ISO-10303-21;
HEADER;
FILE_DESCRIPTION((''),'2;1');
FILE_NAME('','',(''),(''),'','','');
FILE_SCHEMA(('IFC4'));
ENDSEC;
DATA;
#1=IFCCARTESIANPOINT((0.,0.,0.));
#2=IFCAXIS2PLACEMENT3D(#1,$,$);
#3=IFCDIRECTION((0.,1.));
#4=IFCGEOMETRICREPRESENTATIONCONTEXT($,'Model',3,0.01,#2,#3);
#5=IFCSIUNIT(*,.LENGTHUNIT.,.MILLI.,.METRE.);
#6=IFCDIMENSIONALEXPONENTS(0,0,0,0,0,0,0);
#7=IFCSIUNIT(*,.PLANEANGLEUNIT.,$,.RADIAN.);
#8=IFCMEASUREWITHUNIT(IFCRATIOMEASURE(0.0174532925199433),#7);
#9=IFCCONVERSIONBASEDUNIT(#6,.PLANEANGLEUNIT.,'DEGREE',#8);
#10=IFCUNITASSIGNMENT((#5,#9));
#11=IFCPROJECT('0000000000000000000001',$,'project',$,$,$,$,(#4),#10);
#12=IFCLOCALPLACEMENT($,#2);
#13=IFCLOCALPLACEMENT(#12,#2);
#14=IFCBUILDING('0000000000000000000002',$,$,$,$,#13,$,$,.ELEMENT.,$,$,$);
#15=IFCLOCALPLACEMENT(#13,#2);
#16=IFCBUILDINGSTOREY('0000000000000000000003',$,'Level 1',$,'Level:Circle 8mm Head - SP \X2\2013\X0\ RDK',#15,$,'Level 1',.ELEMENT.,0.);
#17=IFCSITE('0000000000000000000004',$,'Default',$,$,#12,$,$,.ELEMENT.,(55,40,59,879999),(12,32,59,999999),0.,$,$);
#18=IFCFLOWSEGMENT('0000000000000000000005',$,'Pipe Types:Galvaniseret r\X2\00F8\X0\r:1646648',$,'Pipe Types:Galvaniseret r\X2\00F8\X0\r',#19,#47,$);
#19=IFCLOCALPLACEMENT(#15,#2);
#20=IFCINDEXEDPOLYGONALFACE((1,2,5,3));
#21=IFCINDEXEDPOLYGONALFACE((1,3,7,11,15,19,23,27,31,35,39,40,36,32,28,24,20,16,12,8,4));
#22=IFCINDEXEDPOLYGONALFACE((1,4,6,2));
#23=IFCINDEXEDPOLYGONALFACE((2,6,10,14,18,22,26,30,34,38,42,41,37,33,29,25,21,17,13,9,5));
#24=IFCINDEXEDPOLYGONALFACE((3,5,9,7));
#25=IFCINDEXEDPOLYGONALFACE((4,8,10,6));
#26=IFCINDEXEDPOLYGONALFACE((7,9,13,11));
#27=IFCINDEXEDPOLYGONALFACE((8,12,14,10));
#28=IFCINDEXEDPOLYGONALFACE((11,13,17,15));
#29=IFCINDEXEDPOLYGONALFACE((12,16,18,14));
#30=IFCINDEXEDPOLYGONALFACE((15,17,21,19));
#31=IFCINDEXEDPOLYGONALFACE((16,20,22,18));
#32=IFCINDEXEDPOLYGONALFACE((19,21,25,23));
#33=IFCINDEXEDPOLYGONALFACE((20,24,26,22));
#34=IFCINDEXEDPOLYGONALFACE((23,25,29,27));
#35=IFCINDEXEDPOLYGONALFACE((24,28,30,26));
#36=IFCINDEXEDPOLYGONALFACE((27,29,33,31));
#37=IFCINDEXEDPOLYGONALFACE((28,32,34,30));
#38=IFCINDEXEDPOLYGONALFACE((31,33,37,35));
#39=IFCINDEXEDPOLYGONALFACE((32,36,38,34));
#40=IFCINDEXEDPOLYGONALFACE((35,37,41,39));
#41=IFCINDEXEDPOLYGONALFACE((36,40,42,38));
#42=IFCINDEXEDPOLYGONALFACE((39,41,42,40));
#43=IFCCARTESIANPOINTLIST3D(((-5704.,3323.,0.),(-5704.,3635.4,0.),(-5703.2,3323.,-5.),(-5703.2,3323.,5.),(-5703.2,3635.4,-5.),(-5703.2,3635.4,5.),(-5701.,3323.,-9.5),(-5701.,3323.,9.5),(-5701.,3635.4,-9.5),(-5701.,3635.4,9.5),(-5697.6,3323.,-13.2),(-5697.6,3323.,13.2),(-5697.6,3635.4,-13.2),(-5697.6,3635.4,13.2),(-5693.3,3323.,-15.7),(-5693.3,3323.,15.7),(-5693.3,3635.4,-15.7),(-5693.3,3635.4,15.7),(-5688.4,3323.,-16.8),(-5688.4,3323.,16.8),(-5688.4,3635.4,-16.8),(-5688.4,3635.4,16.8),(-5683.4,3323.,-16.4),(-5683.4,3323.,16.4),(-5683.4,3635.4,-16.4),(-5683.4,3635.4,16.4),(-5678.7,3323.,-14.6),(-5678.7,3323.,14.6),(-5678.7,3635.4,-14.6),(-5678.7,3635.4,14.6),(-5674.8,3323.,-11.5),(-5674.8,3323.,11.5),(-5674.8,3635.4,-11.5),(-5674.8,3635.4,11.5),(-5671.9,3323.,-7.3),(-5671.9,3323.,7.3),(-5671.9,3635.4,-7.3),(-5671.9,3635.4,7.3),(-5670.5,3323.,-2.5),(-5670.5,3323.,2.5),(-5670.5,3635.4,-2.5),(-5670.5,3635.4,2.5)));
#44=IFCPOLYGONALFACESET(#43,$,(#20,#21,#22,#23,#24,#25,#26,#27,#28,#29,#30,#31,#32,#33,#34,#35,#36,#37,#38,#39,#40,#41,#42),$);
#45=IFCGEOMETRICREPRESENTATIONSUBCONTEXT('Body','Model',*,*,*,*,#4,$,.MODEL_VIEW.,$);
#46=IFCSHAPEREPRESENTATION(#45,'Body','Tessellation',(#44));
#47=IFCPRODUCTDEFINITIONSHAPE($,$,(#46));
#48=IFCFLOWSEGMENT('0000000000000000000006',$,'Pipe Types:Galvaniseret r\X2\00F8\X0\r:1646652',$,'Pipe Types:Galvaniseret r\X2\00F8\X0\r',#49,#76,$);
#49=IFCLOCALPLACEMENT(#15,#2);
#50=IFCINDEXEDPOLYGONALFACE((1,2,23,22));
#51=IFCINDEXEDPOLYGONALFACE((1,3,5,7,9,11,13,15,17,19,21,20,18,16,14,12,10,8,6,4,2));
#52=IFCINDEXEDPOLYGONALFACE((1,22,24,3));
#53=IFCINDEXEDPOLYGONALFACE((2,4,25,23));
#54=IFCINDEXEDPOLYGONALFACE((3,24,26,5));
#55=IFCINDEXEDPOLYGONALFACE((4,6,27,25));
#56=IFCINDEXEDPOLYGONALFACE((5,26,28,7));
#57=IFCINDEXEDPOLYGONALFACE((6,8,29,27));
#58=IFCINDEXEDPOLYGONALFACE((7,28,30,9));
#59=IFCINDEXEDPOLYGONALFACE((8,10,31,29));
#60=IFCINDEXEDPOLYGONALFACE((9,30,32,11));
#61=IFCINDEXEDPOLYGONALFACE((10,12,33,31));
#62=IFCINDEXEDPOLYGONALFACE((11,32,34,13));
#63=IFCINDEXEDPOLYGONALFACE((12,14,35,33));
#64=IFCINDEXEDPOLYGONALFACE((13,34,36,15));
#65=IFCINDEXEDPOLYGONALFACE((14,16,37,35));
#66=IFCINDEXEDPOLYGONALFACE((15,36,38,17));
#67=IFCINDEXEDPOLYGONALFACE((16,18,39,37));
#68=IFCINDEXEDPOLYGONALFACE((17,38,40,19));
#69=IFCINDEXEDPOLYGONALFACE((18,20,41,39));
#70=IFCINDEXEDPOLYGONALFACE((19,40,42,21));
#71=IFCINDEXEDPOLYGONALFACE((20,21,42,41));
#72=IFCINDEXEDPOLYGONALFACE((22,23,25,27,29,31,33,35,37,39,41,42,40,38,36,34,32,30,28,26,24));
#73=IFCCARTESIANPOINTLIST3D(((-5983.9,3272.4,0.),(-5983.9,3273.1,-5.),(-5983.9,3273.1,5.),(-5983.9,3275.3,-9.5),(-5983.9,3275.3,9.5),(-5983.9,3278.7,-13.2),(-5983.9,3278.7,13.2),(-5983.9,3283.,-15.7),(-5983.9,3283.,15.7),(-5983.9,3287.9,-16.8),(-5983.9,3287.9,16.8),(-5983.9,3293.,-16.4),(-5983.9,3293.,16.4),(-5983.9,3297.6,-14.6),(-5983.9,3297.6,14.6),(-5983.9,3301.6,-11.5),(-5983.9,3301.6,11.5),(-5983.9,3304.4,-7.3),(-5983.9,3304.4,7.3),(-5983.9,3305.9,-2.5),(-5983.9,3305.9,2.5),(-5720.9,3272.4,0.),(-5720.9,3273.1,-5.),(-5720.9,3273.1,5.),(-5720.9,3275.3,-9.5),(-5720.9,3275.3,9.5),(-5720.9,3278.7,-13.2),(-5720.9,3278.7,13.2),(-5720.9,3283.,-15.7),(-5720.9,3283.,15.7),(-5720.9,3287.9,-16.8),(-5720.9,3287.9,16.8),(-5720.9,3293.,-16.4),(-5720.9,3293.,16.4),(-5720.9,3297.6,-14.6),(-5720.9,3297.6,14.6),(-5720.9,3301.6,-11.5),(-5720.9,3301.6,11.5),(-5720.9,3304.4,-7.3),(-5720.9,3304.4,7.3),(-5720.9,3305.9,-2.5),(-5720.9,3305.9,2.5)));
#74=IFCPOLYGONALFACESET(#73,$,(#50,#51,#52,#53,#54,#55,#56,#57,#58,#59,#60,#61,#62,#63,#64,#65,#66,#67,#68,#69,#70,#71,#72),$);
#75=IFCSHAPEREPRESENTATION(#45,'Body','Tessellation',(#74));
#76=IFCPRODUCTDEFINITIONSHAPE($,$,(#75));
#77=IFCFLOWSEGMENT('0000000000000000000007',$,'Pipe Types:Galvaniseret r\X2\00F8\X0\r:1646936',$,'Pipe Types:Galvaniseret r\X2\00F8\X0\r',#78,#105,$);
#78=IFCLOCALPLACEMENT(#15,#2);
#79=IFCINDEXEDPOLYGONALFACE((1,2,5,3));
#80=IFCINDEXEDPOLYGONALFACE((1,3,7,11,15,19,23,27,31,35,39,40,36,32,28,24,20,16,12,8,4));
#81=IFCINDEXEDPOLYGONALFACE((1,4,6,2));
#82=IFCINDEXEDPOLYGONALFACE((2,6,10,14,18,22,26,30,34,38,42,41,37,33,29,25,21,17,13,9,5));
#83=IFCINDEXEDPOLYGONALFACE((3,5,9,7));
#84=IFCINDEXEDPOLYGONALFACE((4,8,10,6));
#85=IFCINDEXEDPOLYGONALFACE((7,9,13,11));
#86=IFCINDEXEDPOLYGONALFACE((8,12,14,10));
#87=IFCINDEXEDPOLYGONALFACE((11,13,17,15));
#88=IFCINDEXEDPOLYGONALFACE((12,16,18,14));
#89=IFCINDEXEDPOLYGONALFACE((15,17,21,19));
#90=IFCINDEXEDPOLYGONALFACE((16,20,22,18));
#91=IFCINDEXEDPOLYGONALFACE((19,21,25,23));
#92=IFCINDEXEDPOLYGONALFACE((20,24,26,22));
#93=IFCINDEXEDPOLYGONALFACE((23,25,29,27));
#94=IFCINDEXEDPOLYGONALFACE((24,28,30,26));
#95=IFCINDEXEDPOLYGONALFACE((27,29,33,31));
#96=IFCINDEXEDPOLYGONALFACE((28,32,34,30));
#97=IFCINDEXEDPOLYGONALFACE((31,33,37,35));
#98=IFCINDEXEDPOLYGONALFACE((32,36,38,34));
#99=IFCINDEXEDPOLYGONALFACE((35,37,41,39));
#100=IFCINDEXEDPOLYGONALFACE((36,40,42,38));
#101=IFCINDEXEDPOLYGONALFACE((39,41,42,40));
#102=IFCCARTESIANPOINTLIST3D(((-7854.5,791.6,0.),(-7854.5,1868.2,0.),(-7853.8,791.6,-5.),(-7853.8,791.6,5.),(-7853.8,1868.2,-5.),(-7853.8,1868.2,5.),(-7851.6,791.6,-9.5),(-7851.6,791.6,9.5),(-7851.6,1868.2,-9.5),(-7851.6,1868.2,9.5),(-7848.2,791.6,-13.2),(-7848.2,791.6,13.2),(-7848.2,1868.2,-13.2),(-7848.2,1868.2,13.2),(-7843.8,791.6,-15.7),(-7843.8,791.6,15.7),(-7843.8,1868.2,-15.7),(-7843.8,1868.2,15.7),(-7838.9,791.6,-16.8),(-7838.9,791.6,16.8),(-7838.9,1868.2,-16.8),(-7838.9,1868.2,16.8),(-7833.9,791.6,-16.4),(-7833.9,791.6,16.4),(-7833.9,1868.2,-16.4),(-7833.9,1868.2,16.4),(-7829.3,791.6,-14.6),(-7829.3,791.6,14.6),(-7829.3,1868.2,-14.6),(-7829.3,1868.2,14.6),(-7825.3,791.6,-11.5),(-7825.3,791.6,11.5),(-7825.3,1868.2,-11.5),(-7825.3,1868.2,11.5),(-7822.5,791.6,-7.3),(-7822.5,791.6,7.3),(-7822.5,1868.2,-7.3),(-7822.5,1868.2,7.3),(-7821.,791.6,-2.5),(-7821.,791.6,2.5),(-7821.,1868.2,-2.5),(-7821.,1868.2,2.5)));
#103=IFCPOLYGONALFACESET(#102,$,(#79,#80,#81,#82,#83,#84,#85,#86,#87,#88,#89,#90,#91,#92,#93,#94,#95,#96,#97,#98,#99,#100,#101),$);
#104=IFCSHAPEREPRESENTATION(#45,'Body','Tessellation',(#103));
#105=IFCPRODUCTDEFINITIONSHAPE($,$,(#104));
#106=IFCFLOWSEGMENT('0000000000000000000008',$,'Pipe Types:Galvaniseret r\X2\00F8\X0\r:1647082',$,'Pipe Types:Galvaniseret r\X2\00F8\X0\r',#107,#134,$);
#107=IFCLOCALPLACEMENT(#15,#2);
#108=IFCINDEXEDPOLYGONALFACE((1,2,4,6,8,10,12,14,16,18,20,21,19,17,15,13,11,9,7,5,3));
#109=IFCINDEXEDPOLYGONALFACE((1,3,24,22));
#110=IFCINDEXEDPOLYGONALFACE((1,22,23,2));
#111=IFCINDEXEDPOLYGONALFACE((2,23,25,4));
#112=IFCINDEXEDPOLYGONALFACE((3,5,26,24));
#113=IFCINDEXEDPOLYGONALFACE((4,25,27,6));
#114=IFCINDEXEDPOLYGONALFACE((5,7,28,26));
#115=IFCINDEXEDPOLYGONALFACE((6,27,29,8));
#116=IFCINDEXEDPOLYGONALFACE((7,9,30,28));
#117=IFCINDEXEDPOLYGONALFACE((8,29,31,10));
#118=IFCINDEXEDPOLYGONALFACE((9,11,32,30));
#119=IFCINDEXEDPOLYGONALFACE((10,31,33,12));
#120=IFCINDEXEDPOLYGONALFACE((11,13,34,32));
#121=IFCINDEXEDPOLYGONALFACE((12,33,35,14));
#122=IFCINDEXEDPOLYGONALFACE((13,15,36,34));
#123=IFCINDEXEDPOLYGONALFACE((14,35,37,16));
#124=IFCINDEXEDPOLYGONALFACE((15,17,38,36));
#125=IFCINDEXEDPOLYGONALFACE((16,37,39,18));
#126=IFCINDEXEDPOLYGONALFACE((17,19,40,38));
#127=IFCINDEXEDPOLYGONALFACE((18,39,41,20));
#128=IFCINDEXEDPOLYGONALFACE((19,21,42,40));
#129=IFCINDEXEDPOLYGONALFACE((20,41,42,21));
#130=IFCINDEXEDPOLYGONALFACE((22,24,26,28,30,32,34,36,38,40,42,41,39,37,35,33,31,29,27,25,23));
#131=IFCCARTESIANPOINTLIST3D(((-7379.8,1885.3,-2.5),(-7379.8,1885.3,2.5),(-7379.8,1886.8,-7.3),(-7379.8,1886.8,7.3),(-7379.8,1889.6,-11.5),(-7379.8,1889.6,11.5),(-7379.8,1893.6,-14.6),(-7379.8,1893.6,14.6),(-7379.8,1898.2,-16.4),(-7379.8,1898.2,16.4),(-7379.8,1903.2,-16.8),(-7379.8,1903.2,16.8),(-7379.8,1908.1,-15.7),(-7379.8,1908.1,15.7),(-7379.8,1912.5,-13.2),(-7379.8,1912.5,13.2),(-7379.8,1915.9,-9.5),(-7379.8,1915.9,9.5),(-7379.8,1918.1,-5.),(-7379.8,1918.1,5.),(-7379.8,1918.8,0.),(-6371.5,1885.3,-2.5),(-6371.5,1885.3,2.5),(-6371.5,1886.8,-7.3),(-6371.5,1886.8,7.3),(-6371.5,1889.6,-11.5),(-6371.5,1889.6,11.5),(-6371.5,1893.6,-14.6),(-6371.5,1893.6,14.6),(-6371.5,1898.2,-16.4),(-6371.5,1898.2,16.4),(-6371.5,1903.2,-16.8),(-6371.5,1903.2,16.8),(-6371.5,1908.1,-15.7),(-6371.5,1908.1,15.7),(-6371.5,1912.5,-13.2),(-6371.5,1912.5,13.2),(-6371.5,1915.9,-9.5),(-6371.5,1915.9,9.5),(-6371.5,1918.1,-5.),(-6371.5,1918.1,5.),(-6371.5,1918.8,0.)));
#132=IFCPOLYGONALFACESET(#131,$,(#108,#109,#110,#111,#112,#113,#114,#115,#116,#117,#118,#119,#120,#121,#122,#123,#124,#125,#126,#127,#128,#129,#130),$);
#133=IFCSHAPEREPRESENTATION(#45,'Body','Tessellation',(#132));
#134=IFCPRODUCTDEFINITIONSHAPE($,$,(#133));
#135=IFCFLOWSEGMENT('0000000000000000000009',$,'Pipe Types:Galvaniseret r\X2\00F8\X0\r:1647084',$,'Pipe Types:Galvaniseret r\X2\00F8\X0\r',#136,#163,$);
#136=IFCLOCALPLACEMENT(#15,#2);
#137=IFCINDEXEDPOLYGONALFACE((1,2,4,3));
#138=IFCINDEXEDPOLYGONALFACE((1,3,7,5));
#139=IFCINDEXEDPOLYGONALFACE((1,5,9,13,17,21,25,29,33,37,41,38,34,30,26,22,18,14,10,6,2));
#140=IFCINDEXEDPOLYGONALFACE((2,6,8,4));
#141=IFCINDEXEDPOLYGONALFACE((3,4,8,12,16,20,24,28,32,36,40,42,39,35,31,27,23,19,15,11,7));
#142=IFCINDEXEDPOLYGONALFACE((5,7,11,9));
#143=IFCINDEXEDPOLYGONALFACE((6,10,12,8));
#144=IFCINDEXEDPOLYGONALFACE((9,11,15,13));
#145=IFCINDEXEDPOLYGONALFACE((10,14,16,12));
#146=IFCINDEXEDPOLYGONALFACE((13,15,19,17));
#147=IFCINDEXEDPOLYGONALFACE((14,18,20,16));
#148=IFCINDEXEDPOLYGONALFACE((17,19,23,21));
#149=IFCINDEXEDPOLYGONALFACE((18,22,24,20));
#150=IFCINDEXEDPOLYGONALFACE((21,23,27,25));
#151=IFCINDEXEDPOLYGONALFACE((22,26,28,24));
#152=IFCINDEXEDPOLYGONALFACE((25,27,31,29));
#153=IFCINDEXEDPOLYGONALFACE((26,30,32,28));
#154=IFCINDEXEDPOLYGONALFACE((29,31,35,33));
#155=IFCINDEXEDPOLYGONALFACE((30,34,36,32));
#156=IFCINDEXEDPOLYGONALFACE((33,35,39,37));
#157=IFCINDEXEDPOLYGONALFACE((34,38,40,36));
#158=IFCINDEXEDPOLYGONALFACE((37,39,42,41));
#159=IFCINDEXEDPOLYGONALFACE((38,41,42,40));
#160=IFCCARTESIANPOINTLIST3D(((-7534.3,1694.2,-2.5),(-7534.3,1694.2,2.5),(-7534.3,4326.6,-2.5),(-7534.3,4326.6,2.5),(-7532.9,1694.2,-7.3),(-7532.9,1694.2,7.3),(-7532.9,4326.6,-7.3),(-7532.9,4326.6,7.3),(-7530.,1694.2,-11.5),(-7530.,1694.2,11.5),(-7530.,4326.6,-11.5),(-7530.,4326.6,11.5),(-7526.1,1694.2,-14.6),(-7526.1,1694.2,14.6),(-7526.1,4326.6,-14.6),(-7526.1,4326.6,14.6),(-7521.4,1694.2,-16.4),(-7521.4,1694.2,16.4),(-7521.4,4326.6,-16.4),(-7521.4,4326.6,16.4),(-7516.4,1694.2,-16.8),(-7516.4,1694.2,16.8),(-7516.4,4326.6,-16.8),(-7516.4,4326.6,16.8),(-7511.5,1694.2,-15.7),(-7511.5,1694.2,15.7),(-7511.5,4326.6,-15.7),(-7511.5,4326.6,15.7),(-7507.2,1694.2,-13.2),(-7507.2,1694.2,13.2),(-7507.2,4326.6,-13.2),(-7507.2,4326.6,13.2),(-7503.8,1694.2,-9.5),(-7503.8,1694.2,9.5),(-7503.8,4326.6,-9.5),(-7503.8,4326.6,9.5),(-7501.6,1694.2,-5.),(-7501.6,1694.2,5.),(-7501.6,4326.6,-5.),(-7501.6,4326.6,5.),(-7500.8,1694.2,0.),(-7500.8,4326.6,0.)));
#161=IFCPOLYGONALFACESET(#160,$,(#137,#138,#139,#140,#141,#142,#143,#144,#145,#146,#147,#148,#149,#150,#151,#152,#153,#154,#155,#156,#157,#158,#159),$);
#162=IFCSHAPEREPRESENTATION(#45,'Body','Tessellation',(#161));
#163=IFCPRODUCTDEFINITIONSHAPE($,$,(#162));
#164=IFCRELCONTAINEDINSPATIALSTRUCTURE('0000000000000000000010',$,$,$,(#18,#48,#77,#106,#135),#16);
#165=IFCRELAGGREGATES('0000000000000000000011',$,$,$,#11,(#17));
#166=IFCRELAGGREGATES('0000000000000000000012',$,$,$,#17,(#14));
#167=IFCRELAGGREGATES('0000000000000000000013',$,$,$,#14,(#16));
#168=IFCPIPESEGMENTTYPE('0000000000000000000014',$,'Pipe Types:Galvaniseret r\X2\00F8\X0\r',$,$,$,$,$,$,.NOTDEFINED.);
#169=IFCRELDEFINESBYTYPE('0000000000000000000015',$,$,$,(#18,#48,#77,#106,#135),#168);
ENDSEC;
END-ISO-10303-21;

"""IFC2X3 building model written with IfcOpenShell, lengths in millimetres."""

from ifc_helpers import new_model, entity, si_unit, converted_unit, direction, frame, frame_2d, origin, place, context, subcontext, project, spatial, circle, extrude, type_object, element, save


model = new_model("IFC2X3")

# Units and contexts
model_context = context("Model", 3, precision=0.01, world=origin(), true_north=direction((0.0, 1.0)))
body_context = subcontext(model_context, "Body", "Model", "MODEL_VIEW")
ifc_project = project(units=[si_unit("LENGTHUNIT", "METRE", prefix="MILLI"), converted_unit("PLANEANGLEUNIT", "DEGREE", entity("IfcRatioMeasure", 0.0174532925199433), si_unit("PLANEANGLEUNIT", "RADIAN"), dimensions=[0, 0, 0, 0, 0, 0, 0])], contexts=[model_context])

# Site, building, storey
site_placement = place(None, origin())
site = spatial("IfcSite", under=ifc_project, at=site_placement, Name="Default", CompositionType="ELEMENT", RefLatitude=(55, 40, 59, 879999), RefLongitude=(12, 32, 59, 999999), RefElevation=0.0)
building_placement = place(site_placement, origin())
building = spatial("IfcBuilding", under=site, at=building_placement, CompositionType="ELEMENT")
storey_placement = place(building_placement, origin())
storey = spatial("IfcBuildingStorey", under=building, at=storey_placement, Name="Level 1", ObjectType="Level:Circle 8mm Head - SP – RDK", LongName="Level 1", CompositionType="ELEMENT", Elevation=0.0)

# Flow segments
pipe_segment_type = type_object("IfcPipeSegmentType", Name="Pipe Types:Galvaniseret rør", PredefinedType="NOTDEFINED")
flow_segment_1_placement = place(storey_placement, origin())
element("IfcFlowSegment", 1, at=flow_segment_1_placement, inside=storey, type_object=pipe_segment_type, Name="Pipe Types:Galvaniseret rør:1646648", ObjectType="Pipe Types:Galvaniseret rør", context=body_context, shape_type="SweptSolid", body=[
    extrude(circle(Radius=16.9, at=frame_2d((0.0, 0.0), x_axis=(1.0, 0.0))), frame((-5687.1, 3323.0, 0.0), z_axis=(0.0, 1.0, 0.0), x_axis=(-1.0, 0.0, 0.0)), (0.0, 0.0, 1.0), 312.4),
])
flow_segment_2_placement = place(storey_placement, origin())
element("IfcFlowSegment", 2, at=flow_segment_2_placement, inside=storey, type_object=pipe_segment_type, Name="Pipe Types:Galvaniseret rør:1646652", ObjectType="Pipe Types:Galvaniseret rør", context=body_context, shape_type="SweptSolid", body=[
    extrude(circle(Radius=16.9, at=frame_2d((0.0, 0.0), x_axis=(1.0, 0.0))), frame((-5983.9, 3289.2, 0.0), z_axis=(1.0, 0.0, 0.0), x_axis=(0.0, -1.0, 0.0)), (0.0, 0.0, 1.0), 263.0),
])
flow_segment_3_placement = place(storey_placement, origin())
element("IfcFlowSegment", 3, at=flow_segment_3_placement, inside=storey, type_object=pipe_segment_type, Name="Pipe Types:Galvaniseret rør:1646936", ObjectType="Pipe Types:Galvaniseret rør", context=body_context, shape_type="SweptSolid", body=[
    extrude(circle(Radius=16.9, at=frame_2d((0.0, 0.0), x_axis=(1.0, 0.0))), frame((-7837.7, 791.6, 0.0), z_axis=(0.0, 1.0, 0.0), x_axis=(-1.0, 0.0, 0.0)), (0.0, 0.0, 1.0), 1076.6),
])
flow_segment_4_placement = place(storey_placement, origin())
element("IfcFlowSegment", 4, at=flow_segment_4_placement, inside=storey, type_object=pipe_segment_type, Name="Pipe Types:Galvaniseret rør:1647082", ObjectType="Pipe Types:Galvaniseret rør", context=body_context, shape_type="SweptSolid", body=[
    extrude(circle(Radius=16.9, at=frame_2d((0.0, 0.0), x_axis=(1.0, 0.0))), frame((-7379.8, 1902.0, 0.0), z_axis=(1.0, 0.0, 0.0), x_axis=(0.0, 1.0, 0.0)), (0.0, 0.0, 1.0), 1008.3),
])
flow_segment_5_placement = place(storey_placement, origin())
element("IfcFlowSegment", 5, at=flow_segment_5_placement, inside=storey, type_object=pipe_segment_type, Name="Pipe Types:Galvaniseret rør:1647084", ObjectType="Pipe Types:Galvaniseret rør", context=body_context, shape_type="SweptSolid", body=[
    extrude(circle(Radius=16.9, at=frame_2d((0.0, 0.0), x_axis=(1.0, 0.0))), frame((-7517.7, 1694.2, 0.0), z_axis=(0.0, 1.0, 0.0), x_axis=(1.0, 0.0, 0.0)), (0.0, 0.0, 1.0), 2632.4),
])

save(model, "model.ifc")
